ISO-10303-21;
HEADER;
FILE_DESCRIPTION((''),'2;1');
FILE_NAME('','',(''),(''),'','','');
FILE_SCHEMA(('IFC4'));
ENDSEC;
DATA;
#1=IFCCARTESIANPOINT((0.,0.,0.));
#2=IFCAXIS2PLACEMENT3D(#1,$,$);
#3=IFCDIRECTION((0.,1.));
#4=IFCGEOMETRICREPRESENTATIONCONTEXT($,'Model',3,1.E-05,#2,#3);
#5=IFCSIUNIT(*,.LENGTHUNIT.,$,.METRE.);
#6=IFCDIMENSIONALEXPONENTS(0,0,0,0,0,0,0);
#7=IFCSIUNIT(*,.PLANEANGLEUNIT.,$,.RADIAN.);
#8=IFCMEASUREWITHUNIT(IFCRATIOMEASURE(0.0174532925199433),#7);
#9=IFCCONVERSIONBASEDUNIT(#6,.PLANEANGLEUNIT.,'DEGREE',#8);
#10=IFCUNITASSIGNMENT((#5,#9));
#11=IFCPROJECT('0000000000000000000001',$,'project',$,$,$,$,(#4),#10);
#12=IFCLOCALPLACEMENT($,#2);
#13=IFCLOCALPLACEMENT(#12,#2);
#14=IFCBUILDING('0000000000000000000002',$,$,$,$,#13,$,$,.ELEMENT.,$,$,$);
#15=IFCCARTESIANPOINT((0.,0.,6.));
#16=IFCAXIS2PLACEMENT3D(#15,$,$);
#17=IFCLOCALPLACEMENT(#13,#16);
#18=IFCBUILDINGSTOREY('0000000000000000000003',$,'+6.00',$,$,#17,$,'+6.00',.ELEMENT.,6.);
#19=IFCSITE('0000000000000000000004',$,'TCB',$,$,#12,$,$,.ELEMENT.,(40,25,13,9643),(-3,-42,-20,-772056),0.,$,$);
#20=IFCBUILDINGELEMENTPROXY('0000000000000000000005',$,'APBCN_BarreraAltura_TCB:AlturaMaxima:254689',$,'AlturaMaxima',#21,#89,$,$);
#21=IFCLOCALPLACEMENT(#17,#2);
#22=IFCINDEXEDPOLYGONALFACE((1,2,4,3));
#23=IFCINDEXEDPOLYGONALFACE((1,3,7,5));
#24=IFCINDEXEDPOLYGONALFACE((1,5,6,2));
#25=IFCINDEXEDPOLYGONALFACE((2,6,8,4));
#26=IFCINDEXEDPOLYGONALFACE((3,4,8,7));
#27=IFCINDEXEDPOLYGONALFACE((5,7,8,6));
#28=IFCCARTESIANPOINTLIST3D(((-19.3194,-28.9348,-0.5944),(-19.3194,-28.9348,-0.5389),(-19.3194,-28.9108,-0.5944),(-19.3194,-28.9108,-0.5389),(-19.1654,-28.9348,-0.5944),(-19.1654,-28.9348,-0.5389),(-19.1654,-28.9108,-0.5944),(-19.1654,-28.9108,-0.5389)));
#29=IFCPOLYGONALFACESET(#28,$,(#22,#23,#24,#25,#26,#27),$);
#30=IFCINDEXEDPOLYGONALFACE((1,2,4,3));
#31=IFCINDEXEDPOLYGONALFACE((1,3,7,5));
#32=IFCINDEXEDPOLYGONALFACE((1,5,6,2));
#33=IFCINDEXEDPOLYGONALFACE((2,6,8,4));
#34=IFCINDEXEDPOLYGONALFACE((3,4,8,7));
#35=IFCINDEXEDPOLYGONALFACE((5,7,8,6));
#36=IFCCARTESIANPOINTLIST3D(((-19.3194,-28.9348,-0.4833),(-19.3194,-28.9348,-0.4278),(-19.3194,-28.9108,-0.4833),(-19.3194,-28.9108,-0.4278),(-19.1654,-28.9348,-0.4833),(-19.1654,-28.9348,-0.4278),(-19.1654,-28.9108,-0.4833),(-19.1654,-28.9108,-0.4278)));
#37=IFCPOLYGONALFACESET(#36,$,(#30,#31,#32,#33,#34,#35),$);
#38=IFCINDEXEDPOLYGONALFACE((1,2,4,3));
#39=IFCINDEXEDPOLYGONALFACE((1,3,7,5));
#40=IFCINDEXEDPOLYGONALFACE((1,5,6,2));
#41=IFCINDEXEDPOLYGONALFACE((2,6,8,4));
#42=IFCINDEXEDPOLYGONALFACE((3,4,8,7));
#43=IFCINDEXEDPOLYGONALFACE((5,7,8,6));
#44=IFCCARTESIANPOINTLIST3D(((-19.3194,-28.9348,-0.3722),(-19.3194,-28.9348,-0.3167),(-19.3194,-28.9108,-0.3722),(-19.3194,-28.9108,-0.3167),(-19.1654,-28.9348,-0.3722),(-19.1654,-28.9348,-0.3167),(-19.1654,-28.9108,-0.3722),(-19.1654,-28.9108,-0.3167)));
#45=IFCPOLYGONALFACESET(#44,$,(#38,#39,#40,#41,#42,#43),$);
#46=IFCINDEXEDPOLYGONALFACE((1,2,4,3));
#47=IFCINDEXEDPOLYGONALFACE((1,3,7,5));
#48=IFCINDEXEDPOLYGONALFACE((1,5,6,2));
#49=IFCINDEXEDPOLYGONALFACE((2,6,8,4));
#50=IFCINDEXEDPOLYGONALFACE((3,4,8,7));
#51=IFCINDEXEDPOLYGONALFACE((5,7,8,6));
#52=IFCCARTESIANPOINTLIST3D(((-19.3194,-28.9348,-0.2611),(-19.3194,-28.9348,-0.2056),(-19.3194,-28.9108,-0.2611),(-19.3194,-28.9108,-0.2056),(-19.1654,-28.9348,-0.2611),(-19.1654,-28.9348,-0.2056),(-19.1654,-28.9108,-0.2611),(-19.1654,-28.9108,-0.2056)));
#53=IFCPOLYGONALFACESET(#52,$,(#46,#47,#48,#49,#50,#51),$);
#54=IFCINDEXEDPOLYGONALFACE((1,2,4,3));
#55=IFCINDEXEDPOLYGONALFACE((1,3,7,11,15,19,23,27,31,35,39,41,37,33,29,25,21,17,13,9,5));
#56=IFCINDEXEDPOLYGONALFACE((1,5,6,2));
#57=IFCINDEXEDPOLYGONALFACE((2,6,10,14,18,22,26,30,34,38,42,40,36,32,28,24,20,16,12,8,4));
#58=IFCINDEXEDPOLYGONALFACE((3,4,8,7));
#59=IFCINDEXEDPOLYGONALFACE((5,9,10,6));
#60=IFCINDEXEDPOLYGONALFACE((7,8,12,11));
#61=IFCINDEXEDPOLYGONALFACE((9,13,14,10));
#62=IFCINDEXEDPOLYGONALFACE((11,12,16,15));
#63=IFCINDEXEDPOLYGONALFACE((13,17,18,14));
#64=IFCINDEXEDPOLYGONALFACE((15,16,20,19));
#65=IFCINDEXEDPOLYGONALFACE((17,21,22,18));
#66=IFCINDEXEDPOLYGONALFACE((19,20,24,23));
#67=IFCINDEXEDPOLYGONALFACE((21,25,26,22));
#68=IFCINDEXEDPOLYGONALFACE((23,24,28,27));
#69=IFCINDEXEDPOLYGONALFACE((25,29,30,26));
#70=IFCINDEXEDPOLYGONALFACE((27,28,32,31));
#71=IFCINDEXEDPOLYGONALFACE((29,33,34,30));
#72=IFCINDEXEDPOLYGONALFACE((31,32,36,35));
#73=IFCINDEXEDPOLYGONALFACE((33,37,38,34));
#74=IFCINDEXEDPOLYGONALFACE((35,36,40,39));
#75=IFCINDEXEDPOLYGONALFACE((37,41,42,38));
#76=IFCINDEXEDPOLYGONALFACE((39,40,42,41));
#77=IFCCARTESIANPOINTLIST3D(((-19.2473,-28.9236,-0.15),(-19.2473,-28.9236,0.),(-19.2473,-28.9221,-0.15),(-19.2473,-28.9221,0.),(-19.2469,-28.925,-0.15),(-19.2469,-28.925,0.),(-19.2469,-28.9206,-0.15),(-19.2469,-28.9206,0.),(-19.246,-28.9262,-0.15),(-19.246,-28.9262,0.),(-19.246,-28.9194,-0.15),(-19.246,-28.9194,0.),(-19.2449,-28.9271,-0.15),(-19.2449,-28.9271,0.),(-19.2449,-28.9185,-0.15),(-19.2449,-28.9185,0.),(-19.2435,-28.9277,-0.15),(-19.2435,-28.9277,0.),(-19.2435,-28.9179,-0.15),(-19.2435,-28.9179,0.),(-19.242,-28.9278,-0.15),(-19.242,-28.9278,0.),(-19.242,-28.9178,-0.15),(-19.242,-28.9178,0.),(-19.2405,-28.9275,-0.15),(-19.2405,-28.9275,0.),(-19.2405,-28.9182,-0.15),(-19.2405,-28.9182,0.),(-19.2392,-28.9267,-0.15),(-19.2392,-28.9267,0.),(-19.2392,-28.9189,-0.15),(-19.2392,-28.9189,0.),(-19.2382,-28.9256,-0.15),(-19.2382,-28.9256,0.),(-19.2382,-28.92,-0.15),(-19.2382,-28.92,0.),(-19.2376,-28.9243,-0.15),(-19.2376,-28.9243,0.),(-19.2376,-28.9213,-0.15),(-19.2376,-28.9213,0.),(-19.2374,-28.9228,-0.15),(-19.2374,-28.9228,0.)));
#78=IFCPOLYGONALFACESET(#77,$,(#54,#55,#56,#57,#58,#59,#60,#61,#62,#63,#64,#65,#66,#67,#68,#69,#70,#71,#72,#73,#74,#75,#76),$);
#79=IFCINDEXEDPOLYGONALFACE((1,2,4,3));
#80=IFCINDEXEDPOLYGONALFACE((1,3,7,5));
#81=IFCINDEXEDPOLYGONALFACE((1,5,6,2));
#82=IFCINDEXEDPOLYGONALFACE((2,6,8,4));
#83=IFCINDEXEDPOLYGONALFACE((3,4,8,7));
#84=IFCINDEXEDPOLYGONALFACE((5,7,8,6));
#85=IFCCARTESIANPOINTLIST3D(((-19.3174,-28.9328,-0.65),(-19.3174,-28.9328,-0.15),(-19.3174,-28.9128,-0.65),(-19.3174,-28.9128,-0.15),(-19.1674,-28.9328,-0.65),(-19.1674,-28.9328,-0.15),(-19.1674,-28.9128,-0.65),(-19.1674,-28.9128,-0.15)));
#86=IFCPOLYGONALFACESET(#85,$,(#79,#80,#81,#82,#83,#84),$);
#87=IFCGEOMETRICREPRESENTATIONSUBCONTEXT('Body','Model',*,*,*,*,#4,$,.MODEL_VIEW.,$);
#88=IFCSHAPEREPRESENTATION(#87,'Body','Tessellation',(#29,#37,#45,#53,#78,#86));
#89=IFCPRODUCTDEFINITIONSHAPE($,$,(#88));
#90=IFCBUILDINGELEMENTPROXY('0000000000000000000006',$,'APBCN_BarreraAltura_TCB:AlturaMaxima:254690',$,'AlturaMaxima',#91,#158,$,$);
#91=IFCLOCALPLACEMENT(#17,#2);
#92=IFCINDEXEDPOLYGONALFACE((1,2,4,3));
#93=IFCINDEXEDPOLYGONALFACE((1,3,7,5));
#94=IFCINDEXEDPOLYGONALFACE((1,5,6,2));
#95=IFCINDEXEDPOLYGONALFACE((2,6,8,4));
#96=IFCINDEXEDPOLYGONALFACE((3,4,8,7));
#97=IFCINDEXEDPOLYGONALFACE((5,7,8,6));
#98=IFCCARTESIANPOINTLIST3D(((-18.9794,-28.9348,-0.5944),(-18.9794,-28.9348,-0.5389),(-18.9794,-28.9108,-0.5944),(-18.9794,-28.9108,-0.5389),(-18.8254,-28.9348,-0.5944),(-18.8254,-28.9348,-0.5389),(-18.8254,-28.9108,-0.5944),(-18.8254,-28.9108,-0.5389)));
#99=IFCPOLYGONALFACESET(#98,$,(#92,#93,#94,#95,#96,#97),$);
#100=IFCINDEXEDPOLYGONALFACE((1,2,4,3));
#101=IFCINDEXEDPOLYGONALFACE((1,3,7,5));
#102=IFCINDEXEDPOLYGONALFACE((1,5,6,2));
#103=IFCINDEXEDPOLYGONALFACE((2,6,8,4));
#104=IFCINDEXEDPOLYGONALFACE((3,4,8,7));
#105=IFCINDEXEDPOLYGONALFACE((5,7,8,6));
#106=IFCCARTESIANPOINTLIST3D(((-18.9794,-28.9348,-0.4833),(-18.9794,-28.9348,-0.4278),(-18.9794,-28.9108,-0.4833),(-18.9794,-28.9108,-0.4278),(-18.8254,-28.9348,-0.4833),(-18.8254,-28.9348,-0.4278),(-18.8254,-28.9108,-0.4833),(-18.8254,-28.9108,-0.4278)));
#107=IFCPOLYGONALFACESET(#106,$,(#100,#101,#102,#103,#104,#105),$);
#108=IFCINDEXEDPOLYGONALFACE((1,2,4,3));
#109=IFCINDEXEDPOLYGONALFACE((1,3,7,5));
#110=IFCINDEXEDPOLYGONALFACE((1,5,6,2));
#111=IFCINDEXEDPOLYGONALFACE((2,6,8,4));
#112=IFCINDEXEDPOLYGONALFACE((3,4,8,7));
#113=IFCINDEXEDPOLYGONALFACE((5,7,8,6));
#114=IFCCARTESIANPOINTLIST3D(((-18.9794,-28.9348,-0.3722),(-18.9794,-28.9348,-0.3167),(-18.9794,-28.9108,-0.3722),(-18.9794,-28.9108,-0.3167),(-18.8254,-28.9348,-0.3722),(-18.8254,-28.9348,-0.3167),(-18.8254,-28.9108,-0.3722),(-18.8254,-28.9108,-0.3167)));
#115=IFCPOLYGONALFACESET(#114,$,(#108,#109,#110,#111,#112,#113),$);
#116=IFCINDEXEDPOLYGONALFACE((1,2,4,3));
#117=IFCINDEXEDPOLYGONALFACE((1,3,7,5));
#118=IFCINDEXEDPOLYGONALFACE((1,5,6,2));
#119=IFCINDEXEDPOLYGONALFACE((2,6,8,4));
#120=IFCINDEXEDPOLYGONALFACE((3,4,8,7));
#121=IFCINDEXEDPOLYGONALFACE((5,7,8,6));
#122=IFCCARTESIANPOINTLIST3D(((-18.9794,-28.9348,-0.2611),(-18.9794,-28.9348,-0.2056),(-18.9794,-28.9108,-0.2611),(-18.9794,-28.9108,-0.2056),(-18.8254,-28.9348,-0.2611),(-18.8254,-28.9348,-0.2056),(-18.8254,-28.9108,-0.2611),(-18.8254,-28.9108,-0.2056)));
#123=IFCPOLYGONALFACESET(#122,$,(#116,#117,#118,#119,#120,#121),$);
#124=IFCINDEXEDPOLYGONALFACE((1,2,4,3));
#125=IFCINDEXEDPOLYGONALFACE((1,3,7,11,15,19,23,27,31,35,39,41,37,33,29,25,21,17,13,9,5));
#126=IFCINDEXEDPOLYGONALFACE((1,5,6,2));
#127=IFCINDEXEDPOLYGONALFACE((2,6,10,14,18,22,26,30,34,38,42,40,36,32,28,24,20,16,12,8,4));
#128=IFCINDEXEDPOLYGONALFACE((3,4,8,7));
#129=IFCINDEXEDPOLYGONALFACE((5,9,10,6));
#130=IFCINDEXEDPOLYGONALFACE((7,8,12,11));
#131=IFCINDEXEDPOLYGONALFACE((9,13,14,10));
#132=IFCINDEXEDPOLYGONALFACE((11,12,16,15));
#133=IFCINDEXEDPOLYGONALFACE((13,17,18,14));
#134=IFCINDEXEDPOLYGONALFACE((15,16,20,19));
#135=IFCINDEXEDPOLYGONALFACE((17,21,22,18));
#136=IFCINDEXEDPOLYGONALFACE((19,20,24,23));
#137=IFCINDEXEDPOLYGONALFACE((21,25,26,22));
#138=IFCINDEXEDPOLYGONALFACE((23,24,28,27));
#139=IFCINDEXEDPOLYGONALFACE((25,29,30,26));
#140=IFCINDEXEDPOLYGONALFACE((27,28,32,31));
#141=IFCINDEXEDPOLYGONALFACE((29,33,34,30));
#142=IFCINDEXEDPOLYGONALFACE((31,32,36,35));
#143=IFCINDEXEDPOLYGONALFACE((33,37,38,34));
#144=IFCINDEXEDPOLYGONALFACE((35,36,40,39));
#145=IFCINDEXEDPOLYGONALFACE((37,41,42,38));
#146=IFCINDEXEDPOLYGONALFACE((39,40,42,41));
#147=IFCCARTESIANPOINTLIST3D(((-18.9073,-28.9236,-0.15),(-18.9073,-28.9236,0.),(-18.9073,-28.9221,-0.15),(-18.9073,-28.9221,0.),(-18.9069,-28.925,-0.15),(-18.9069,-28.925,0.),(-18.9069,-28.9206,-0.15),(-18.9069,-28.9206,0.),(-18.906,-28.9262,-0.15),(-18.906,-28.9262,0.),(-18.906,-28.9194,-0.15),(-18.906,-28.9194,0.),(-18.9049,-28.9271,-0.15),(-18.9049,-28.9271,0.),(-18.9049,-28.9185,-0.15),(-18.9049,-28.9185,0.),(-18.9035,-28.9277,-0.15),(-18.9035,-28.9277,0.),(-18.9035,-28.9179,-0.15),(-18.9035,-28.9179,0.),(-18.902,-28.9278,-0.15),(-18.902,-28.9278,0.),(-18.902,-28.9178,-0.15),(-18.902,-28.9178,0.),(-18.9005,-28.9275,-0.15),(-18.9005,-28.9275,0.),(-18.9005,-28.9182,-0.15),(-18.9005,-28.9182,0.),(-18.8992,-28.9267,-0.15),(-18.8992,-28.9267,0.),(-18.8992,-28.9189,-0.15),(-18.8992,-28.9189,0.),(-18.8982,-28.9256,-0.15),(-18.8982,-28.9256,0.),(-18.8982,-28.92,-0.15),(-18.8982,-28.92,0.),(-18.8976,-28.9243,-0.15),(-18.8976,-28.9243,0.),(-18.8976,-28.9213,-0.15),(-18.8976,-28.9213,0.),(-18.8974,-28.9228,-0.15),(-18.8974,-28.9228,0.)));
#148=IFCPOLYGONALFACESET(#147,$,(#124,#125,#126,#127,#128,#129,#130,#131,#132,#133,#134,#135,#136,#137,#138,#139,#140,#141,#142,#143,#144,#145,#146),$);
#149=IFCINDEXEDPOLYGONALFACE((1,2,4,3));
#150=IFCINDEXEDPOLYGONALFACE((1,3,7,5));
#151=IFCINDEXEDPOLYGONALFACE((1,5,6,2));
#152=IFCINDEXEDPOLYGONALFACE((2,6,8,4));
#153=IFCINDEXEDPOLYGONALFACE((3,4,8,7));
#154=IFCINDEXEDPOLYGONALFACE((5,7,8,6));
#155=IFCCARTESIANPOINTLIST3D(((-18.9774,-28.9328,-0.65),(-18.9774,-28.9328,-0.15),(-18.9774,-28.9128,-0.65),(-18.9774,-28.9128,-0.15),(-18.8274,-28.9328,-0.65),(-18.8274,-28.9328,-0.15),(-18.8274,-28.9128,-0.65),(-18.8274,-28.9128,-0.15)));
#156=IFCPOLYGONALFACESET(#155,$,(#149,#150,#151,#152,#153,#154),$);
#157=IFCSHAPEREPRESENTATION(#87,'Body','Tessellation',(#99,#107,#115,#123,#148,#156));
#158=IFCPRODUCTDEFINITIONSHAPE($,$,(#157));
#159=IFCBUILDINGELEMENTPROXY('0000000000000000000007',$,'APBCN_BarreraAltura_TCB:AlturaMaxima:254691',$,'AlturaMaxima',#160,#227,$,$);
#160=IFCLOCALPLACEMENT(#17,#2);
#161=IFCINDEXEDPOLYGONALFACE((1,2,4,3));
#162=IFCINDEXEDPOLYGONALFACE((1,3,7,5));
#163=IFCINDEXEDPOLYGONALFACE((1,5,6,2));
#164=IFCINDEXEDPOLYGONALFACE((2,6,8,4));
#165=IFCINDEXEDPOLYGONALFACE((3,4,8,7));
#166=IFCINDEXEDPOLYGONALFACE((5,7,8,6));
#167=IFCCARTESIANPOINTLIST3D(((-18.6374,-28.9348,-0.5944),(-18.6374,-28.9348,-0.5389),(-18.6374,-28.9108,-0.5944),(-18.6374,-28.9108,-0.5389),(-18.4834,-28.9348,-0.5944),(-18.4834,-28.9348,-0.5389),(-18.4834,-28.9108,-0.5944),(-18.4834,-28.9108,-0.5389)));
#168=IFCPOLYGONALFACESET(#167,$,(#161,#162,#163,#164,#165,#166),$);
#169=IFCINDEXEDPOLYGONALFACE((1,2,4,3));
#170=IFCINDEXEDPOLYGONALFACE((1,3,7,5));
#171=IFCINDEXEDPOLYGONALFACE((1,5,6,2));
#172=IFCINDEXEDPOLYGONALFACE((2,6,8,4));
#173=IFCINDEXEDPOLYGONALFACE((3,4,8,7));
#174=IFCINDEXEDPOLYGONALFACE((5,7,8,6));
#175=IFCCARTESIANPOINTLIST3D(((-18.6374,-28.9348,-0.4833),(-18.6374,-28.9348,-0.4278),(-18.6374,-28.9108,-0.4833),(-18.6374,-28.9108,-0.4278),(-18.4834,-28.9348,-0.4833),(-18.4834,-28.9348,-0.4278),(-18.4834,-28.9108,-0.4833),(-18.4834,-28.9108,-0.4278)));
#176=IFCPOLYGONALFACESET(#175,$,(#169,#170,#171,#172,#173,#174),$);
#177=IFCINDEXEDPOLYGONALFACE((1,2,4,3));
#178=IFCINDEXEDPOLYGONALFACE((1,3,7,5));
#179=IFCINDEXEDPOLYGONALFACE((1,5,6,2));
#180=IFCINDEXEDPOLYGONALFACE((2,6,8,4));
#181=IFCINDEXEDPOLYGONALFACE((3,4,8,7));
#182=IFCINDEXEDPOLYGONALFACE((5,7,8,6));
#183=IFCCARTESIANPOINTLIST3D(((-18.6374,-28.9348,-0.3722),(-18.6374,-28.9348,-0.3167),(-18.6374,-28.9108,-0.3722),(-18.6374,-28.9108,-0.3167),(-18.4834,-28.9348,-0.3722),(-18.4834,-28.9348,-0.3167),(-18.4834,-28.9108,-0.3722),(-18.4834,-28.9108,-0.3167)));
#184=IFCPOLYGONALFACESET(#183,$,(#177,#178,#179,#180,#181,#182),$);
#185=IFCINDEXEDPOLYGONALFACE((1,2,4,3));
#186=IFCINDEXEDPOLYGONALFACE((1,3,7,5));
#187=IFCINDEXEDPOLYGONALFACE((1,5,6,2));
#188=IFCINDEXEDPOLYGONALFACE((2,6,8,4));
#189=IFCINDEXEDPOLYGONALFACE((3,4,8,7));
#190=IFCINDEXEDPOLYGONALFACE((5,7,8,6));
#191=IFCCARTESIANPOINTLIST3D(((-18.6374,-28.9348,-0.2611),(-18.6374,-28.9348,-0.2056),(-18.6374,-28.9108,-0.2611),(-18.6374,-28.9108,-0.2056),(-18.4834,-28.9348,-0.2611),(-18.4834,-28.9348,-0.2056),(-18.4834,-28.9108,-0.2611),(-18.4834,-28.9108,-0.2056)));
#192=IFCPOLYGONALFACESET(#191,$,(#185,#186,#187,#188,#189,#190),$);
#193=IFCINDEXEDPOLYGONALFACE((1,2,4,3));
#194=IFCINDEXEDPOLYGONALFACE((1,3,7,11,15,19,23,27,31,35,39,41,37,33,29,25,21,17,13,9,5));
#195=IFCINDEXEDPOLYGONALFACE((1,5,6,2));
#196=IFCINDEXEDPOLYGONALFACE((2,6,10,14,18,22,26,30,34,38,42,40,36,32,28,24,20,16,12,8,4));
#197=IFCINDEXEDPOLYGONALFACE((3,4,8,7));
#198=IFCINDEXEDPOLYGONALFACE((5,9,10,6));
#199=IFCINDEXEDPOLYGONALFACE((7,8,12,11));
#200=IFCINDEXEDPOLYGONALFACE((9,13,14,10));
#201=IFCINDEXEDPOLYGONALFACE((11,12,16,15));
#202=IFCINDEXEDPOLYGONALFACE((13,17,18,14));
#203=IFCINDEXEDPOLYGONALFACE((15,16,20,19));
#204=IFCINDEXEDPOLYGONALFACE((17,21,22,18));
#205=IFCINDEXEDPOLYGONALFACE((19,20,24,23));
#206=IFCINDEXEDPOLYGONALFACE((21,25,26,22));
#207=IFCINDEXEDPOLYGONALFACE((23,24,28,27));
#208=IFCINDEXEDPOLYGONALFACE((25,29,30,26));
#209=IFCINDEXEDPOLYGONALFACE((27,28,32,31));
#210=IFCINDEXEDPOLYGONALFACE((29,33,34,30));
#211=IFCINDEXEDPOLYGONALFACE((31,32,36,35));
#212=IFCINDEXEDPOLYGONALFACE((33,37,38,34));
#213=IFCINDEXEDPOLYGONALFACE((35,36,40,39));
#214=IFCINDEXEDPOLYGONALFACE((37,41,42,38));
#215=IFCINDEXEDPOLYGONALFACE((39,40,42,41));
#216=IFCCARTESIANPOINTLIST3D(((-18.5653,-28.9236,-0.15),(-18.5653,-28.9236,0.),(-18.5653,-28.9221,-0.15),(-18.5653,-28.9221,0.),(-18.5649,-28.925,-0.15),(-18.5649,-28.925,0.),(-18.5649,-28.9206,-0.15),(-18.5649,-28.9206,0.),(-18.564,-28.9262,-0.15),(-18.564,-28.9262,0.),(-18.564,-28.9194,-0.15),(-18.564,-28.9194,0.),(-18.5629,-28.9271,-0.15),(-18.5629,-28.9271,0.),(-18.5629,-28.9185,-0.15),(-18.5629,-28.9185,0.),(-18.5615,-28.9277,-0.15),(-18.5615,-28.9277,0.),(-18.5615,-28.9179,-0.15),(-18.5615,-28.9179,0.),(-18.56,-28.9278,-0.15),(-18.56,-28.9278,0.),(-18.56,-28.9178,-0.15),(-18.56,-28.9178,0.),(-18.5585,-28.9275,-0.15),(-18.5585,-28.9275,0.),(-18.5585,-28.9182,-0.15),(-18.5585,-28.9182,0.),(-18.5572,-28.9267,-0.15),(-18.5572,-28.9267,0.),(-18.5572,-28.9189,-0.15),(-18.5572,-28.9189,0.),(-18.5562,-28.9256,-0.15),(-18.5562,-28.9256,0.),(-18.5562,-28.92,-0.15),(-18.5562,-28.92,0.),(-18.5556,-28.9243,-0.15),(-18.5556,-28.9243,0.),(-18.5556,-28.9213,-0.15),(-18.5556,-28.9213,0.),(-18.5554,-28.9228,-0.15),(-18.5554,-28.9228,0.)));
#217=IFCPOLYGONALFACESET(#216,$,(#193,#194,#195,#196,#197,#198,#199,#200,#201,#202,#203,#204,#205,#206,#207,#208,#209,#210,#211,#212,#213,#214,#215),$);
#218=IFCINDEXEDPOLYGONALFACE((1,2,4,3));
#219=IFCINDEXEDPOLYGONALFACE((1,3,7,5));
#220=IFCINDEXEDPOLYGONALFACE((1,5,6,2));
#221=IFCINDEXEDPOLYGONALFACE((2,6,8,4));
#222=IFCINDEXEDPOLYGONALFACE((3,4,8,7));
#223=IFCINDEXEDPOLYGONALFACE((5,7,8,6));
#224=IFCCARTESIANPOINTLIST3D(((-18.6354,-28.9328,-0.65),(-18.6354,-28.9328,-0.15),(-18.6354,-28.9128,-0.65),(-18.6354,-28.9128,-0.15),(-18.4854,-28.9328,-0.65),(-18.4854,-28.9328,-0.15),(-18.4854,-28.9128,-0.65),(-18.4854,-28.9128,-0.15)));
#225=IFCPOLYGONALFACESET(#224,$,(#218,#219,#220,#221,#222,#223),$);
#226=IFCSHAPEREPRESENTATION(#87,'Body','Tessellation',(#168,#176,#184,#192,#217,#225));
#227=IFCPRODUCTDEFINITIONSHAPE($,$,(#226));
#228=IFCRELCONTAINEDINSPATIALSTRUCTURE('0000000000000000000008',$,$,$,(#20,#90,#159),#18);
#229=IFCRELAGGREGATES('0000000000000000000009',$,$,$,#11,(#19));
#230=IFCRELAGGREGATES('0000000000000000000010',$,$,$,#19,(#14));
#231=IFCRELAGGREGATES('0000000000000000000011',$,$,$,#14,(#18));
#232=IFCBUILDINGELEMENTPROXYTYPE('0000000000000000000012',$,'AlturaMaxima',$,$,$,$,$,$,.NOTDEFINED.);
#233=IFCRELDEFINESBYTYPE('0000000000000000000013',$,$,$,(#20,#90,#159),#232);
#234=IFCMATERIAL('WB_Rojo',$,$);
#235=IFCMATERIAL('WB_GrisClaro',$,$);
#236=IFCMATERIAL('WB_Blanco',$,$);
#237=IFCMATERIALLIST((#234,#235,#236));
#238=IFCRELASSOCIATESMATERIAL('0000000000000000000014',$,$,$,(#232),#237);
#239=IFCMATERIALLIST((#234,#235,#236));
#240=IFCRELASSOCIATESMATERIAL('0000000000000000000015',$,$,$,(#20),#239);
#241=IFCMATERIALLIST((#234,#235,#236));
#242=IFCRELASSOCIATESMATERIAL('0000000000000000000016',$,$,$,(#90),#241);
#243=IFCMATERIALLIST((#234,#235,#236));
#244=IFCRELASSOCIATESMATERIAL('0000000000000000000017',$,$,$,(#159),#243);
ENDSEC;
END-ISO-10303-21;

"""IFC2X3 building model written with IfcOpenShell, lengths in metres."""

from ifc_helpers import new_model, entity, si_unit, converted_unit, direction, frame, frame_2d, origin, origin_2d_with_axis, place, context, subcontext, project, spatial, rectangle, circle, extrude, source, transform, mapped, material, material_list, type_object, type_shapes, element, save


model = new_model("IFC2X3")

# Units and contexts
model_context = context("Model", 3, precision=1e-05, world=origin(), true_north=direction((0.0, 1.0)))
body_context = subcontext(model_context, "Body", "Model", "MODEL_VIEW")
ifc_project = project(units=[si_unit("LENGTHUNIT", "METRE"), converted_unit("PLANEANGLEUNIT", "DEGREE", entity("IfcRatioMeasure", 0.0174532925199433), si_unit("PLANEANGLEUNIT", "RADIAN"), dimensions=[0, 0, 0, 0, 0, 0, 0])], contexts=[model_context])

# Site, building, storey
site_placement = place(None, origin())
site = spatial("IfcSite", under=ifc_project, at=site_placement, Name="TCB", CompositionType="ELEMENT", RefLatitude=(40, 25, 13, 9643), RefLongitude=(-3, -42, -20, -772056), RefElevation=0.0)
building_placement = place(site_placement, origin())
building = spatial("IfcBuilding", under=site, at=building_placement, CompositionType="ELEMENT")
storey_placement = place(building_placement, frame((0.0, 0.0, 6.0)))
storey = spatial("IfcBuildingStorey", under=building, at=storey_placement, Name="+6.00", LongName="+6.00", CompositionType="ELEMENT", Elevation=6.0)

# Building element proxies
ifc_material_1 = material(Name="WB_Rojo")
ifc_material_2 = material(Name="WB_GrisClaro")
ifc_material_3 = material(Name="WB_Blanco")
ifc_material_list_1 = material_list([ifc_material_1, ifc_material_2, ifc_material_3])
building_element_proxy_type = type_object("IfcBuildingElementProxyType", Name="AlturaMaxima", PredefinedType="NOTDEFINED", material=ifc_material_list_1)
shared_shape = source(origin(), body_context, "Body", "SweptSolid", [
    extrude(rectangle(XDim=0.154, YDim=0.024, at=frame_2d((0.0, 0.0), x_axis=(1.0, 0.0))), frame((0.0, 0.0, -0.5944), z_axis=(0.0, 0.0, 1.0), x_axis=(-1.0, 0.0, 0.0)), (0.0, 0.0, 1.0), 0.0556),
    extrude(rectangle(XDim=0.154, YDim=0.024, at=frame_2d((0.0, 0.0), x_axis=(1.0, 0.0))), frame((0.0, 0.0, -0.4833), z_axis=(0.0, 0.0, 1.0), x_axis=(-1.0, 0.0, 0.0)), (0.0, 0.0, 1.0), 0.0556),
    extrude(rectangle(XDim=0.154, YDim=0.024, at=frame_2d((0.0, 0.0), x_axis=(1.0, 0.0))), frame((0.0, 0.0, -0.3722), z_axis=(0.0, 0.0, 1.0), x_axis=(-1.0, 0.0, 0.0)), (0.0, 0.0, 1.0), 0.0556),
    extrude(rectangle(XDim=0.154, YDim=0.024, at=frame_2d((0.0, 0.0), x_axis=(1.0, 0.0))), frame((0.0, 0.0, -0.2611), z_axis=(0.0, 0.0, 1.0), x_axis=(-1.0, 0.0, 0.0)), (0.0, 0.0, 1.0), 0.0556),
    extrude(circle(Radius=0.005, at=frame_2d((0.0, 0.0), x_axis=(1.0, 0.0))), frame((0.0, 0.0, -0.15)), (0.0, 0.0, 1.0), 0.15),
    extrude(rectangle(XDim=0.02, YDim=0.15, at=origin_2d_with_axis()), frame((0.0, 0.0, -0.65), z_axis=(0.0, 0.0, 1.0), x_axis=(0.0, 1.0, 0.0)), (0.0, 0.0, 1.0), 0.5),
])
type_shapes(building_element_proxy_type, [shared_shape])
ifc_material_list_2 = material_list([ifc_material_1, ifc_material_2, ifc_material_3])
proxy_1_placement = place(storey_placement, frame((-19.2424, -28.9228, 0.0)))
element("IfcBuildingElementProxy", 1, at=proxy_1_placement, inside=storey, type_object=building_element_proxy_type, material=ifc_material_list_2, Name="APBCN_BarreraAltura_TCB:AlturaMaxima:254689", ObjectType="AlturaMaxima", context=body_context, shape_type="MappedRepresentation", body=[
    mapped(shared_shape, transform((0.0, 0.0, 0.0), scale=1.0)),
])
ifc_material_list_3 = material_list([ifc_material_1, ifc_material_2, ifc_material_3])
proxy_2_placement = place(storey_placement, frame((-18.9024, -28.9228, 0.0)))
element("IfcBuildingElementProxy", 2, at=proxy_2_placement, inside=storey, type_object=building_element_proxy_type, material=ifc_material_list_3, Name="APBCN_BarreraAltura_TCB:AlturaMaxima:254690", ObjectType="AlturaMaxima", context=body_context, shape_type="MappedRepresentation", body=[
    mapped(shared_shape, transform((0.0, 0.0, 0.0), scale=1.0)),
])
ifc_material_list_4 = material_list([ifc_material_1, ifc_material_2, ifc_material_3])
proxy_3_placement = place(storey_placement, frame((-18.5604, -28.9228, 0.0)))
element("IfcBuildingElementProxy", 3, at=proxy_3_placement, inside=storey, type_object=building_element_proxy_type, material=ifc_material_list_4, Name="APBCN_BarreraAltura_TCB:AlturaMaxima:254691", ObjectType="AlturaMaxima", context=body_context, shape_type="MappedRepresentation", body=[
    mapped(shared_shape, transform((0.0, 0.0, 0.0), scale=1.0)),
])

save(model, "model.ifc")
